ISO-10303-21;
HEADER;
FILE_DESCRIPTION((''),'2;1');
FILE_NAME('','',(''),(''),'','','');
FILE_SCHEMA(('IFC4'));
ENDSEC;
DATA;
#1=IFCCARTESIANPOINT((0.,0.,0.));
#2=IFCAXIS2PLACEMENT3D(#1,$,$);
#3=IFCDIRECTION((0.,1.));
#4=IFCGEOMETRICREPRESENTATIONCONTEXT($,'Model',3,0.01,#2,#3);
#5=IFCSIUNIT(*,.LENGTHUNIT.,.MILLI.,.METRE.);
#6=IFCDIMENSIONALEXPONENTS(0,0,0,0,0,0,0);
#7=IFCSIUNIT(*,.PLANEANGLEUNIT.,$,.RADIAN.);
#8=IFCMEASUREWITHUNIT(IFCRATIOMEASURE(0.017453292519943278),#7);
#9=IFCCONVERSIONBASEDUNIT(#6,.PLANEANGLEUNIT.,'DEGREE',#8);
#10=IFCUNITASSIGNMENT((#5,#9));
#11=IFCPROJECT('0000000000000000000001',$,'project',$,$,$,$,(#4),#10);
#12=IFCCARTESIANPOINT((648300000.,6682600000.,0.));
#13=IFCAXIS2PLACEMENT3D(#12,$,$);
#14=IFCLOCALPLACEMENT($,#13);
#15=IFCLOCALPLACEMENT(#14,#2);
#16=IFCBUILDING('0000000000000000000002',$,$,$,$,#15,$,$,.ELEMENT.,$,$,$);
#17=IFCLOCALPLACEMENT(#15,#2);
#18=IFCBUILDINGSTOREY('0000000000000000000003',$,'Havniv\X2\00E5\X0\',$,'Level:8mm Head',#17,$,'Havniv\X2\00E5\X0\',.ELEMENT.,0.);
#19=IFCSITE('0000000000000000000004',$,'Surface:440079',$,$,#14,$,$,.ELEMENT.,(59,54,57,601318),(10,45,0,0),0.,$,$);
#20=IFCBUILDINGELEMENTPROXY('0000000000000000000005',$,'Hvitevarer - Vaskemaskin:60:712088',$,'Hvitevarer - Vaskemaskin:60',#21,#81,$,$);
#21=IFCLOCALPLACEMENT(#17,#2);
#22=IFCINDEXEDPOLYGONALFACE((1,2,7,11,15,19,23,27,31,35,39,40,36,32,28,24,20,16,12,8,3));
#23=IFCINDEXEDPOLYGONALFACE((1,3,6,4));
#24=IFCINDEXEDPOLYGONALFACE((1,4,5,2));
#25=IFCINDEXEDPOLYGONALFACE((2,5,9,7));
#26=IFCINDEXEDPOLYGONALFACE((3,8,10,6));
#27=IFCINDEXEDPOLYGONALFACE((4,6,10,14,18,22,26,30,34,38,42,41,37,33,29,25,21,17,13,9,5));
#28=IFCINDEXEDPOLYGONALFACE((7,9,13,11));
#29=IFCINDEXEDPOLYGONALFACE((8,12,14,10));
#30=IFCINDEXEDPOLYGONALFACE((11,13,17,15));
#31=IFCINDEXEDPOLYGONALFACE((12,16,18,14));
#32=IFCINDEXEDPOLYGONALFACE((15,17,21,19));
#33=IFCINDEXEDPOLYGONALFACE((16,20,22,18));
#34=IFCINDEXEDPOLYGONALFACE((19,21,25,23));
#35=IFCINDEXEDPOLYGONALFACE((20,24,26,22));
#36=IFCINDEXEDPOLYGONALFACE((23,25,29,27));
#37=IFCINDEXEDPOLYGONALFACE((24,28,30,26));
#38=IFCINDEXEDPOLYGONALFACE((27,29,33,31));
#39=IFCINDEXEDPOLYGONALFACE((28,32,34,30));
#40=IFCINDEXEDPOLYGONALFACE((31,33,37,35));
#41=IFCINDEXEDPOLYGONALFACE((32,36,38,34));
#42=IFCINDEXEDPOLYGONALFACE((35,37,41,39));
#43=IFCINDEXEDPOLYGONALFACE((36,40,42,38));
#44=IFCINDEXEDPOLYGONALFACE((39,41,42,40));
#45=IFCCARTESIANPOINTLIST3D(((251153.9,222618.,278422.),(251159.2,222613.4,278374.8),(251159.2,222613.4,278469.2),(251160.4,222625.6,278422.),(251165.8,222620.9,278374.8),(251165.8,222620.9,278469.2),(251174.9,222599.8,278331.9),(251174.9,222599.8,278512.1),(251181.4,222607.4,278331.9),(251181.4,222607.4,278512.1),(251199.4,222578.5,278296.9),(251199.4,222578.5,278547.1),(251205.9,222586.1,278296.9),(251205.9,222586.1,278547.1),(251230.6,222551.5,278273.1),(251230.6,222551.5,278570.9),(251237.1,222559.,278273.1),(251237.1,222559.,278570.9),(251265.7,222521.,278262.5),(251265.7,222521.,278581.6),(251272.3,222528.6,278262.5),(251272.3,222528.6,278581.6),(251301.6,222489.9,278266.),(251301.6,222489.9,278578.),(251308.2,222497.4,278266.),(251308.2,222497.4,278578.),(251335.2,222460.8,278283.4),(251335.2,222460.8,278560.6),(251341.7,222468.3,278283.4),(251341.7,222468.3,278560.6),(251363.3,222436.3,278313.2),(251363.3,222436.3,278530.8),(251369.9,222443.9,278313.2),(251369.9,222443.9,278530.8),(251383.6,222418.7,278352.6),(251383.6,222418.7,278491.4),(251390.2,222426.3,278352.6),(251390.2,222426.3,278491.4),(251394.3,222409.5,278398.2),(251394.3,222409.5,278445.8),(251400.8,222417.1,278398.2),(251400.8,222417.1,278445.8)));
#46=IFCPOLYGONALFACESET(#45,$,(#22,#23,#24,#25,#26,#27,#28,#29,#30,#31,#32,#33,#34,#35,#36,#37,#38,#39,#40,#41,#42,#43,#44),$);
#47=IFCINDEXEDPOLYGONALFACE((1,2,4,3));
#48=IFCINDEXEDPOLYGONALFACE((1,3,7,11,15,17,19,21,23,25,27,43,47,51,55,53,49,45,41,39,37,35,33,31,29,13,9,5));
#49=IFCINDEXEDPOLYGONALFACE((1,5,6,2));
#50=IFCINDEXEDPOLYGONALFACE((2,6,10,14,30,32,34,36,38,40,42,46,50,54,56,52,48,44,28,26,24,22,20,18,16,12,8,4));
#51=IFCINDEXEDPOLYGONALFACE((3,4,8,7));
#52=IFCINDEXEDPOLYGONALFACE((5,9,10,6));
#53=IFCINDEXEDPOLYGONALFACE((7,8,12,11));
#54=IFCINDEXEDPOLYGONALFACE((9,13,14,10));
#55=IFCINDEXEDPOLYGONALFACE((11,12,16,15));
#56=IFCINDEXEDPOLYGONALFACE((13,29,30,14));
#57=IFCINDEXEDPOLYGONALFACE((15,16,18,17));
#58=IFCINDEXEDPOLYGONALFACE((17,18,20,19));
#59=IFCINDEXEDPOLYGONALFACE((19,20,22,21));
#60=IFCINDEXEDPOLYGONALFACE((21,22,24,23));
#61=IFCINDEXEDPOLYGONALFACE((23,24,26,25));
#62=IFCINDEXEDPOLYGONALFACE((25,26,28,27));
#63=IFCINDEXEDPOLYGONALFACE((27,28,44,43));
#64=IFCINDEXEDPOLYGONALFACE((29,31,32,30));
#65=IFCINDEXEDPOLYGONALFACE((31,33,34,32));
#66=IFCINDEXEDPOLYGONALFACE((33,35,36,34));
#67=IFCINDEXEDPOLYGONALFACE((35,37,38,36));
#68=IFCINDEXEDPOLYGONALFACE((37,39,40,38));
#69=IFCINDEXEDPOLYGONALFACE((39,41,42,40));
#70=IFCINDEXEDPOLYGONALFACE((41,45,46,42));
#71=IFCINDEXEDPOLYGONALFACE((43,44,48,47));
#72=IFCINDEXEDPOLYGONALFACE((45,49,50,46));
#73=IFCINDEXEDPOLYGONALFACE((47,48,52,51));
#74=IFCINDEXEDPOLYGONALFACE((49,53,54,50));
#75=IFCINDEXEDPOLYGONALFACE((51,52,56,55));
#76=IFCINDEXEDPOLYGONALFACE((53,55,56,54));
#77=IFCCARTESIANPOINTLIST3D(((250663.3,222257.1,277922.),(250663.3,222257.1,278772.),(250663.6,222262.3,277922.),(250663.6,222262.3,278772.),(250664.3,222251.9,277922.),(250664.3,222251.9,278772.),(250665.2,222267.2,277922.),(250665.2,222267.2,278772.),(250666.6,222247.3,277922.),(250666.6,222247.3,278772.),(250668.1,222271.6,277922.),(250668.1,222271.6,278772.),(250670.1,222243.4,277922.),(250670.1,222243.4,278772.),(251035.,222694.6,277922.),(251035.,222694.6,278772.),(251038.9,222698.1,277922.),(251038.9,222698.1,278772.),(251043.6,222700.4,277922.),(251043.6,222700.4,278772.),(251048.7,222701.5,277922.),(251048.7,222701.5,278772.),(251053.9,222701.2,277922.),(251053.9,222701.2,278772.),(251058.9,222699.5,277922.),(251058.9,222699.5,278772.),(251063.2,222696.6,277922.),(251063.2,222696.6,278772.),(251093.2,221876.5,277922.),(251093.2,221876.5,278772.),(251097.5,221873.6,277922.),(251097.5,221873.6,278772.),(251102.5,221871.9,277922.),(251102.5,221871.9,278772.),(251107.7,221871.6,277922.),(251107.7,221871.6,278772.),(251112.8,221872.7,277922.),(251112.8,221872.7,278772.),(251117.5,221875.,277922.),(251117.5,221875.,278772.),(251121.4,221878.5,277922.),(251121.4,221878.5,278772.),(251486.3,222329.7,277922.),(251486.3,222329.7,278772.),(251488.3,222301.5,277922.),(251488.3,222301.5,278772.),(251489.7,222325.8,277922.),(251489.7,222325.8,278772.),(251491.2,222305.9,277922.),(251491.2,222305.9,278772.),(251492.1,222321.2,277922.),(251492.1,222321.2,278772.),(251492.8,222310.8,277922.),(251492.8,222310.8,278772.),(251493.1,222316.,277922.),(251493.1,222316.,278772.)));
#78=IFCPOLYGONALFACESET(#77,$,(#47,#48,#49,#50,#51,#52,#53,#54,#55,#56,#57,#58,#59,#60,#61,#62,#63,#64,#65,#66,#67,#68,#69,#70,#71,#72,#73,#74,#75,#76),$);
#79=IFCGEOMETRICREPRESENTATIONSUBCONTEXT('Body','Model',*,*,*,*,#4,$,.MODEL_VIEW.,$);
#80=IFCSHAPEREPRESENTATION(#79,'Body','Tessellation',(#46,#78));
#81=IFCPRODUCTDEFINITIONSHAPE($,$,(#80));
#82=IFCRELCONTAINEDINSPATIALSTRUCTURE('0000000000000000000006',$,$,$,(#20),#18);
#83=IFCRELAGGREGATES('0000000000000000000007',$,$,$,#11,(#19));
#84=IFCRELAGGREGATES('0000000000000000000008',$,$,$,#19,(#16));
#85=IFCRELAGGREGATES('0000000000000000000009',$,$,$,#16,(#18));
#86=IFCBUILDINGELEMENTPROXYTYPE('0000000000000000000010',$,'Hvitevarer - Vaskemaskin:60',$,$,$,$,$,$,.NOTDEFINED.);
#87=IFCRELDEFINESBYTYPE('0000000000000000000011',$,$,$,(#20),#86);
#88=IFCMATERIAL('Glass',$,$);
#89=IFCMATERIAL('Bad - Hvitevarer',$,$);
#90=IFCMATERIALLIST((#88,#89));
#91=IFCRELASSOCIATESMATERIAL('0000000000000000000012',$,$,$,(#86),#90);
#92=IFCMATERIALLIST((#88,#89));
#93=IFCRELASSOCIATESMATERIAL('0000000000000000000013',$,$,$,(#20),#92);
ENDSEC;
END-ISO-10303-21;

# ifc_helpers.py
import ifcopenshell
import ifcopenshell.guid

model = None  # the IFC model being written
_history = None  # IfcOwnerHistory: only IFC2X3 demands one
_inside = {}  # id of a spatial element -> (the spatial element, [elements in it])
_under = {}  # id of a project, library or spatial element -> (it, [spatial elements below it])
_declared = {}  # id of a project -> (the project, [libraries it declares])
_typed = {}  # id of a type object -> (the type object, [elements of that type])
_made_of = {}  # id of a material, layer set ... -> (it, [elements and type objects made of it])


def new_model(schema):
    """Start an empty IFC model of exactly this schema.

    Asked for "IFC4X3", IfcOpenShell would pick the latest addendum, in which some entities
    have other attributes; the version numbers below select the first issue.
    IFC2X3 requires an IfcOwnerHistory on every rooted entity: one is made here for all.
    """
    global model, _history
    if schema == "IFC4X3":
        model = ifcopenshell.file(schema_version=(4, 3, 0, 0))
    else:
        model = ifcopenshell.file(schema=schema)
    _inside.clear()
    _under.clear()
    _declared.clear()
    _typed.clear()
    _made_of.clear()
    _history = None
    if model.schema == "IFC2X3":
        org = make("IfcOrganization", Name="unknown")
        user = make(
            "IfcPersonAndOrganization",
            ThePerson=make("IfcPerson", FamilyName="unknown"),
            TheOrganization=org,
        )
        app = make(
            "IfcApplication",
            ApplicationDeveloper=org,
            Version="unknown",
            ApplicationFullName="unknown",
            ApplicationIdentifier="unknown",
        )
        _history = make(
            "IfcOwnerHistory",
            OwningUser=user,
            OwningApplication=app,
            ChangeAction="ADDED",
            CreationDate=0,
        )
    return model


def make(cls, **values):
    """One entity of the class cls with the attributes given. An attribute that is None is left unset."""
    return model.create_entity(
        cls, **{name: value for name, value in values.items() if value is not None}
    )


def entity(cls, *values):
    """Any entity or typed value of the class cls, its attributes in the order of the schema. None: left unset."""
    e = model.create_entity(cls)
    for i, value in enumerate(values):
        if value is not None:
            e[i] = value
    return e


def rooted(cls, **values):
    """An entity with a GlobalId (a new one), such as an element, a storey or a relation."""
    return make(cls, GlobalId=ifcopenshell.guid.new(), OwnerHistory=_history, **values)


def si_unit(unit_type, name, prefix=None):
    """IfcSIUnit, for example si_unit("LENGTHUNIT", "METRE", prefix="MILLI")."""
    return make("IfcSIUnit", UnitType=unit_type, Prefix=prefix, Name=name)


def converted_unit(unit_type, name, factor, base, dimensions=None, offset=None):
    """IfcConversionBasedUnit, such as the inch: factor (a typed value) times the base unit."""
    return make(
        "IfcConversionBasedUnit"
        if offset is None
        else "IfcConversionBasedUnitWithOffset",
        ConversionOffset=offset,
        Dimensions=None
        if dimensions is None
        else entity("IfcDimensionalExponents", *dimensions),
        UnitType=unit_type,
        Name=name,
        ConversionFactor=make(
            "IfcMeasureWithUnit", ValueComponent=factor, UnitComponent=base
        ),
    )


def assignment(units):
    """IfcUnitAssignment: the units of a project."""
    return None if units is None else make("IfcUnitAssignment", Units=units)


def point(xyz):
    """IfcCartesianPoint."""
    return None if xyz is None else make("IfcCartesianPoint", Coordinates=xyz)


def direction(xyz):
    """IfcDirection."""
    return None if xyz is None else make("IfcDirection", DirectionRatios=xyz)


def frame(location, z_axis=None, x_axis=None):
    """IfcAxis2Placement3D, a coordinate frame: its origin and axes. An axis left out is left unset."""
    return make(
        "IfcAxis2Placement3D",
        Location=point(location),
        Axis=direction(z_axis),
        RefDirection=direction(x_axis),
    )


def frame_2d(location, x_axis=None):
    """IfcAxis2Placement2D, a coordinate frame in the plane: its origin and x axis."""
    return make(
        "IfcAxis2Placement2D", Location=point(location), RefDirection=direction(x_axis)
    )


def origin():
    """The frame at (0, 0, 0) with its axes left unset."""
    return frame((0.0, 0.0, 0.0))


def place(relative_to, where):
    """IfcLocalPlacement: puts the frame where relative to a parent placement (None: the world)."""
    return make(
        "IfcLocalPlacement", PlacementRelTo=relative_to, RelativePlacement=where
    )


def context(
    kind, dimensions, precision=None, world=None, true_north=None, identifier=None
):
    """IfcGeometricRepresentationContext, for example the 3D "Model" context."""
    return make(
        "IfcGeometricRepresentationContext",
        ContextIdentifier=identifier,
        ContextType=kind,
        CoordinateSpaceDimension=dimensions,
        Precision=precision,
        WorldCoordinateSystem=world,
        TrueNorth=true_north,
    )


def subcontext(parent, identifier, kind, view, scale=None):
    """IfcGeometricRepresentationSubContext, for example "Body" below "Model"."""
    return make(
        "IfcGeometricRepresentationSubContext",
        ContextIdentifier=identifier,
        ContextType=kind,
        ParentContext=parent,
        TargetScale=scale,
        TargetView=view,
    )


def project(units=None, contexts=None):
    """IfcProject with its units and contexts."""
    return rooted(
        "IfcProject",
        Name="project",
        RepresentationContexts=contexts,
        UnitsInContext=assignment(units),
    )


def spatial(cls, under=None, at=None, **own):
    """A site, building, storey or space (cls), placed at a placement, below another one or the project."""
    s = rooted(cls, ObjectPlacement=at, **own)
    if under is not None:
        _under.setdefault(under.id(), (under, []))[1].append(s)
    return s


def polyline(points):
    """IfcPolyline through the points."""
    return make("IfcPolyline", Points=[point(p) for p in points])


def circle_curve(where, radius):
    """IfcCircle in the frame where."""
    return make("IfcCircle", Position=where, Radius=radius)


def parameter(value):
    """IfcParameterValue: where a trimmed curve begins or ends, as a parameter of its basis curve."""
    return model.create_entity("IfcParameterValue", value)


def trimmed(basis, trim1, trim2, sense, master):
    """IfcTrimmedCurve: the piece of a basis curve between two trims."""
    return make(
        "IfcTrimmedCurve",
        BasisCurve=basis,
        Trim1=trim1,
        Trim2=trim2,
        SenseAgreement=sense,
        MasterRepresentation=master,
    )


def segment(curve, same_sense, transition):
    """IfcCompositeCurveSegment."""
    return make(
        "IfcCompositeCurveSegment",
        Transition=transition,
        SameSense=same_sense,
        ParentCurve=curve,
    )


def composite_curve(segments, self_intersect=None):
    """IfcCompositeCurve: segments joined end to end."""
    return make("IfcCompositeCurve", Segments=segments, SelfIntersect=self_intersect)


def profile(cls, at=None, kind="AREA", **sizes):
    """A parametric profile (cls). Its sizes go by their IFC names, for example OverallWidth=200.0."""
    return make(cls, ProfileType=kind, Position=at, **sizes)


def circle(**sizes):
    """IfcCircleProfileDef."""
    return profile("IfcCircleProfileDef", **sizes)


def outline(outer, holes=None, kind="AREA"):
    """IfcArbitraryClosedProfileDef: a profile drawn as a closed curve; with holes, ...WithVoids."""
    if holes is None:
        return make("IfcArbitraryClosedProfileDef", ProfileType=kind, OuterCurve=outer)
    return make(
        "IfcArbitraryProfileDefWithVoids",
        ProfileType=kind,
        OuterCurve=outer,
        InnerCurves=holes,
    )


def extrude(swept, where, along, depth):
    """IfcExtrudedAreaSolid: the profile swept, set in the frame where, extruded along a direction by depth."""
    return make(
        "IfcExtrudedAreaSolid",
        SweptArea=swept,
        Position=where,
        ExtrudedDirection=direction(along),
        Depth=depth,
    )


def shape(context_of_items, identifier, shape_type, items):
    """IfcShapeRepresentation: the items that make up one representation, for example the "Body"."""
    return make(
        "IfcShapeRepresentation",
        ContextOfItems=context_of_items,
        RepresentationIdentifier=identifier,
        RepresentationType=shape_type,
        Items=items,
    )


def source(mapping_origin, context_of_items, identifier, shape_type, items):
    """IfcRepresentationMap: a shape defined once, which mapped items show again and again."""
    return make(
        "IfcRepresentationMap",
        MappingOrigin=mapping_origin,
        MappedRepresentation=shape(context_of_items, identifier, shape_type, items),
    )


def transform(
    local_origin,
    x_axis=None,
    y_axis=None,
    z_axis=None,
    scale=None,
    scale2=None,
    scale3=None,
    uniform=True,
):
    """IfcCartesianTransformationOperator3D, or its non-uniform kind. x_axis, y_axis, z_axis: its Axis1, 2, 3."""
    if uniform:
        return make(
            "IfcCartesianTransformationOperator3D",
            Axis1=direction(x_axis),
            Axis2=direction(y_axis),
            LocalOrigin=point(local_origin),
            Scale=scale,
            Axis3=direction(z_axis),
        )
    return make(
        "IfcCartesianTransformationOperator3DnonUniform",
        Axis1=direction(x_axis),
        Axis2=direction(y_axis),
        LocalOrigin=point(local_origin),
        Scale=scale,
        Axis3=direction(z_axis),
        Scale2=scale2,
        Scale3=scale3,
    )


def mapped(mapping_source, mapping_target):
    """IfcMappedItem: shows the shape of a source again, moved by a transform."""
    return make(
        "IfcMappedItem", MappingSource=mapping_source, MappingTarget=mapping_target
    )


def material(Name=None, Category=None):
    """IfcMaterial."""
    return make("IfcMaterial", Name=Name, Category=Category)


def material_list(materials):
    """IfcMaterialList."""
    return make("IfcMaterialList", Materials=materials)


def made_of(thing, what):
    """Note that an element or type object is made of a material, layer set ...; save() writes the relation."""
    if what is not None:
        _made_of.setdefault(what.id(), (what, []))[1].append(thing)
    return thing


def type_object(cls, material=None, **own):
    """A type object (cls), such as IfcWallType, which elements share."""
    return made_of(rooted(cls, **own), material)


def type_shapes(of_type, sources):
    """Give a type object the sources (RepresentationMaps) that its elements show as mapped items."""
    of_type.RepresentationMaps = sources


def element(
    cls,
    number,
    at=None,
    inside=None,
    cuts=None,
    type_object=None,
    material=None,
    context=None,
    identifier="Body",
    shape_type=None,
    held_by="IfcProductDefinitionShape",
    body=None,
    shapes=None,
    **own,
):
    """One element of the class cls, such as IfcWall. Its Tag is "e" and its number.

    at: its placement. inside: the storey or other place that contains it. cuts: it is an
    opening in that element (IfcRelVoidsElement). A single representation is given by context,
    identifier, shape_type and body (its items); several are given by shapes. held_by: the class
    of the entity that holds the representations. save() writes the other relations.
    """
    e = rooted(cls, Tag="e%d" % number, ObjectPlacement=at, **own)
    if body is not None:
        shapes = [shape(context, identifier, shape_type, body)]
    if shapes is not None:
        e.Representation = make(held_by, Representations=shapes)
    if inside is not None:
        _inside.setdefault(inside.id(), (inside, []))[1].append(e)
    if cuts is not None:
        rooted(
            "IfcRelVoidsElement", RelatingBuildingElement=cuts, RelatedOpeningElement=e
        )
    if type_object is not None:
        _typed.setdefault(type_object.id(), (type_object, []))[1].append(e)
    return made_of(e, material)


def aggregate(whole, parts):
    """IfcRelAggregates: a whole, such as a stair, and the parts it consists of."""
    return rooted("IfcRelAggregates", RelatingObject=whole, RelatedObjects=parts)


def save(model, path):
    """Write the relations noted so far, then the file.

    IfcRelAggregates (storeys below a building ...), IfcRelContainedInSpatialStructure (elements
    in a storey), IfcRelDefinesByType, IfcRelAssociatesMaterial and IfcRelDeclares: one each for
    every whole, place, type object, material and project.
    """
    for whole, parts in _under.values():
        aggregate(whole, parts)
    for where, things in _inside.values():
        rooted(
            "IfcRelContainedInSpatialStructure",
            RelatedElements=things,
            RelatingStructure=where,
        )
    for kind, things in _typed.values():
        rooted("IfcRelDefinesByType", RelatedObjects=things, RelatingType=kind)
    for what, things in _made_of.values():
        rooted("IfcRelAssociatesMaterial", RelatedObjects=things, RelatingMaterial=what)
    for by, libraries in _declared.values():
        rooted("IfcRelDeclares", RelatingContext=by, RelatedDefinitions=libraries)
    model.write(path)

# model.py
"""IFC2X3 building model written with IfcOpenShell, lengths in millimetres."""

from ifc_helpers import new_model, entity, si_unit, converted_unit, direction, frame, frame_2d, origin, place, context, subcontext, project, spatial, polyline, circle_curve, parameter, trimmed, segment, composite_curve, circle, outline, extrude, source, transform, mapped, material, material_list, type_object, type_shapes, element, save


model = new_model("IFC2X3")

# Units and contexts
model_context = context("Model", 3, precision=0.01, world=origin(), true_north=direction((0.0, 1.0)))
body_context = subcontext(model_context, "Body", "Model", "MODEL_VIEW")
ifc_project = project(units=[si_unit("LENGTHUNIT", "METRE", prefix="MILLI"), converted_unit("PLANEANGLEUNIT", "DEGREE", entity("IfcRatioMeasure", 0.017453292519943278), si_unit("PLANEANGLEUNIT", "RADIAN"), dimensions=[0, 0, 0, 0, 0, 0, 0])], contexts=[model_context])

# Site, building, storey
site_placement = place(None, frame((648300000.0, 6682600000.0, 0.0)))
site = spatial("IfcSite", under=ifc_project, at=site_placement, Name="Surface:440079", CompositionType="ELEMENT", RefLatitude=(59, 54, 57, 601318), RefLongitude=(10, 45, 0, 0), RefElevation=0.0)
building_placement = place(site_placement, origin())
building = spatial("IfcBuilding", under=site, at=building_placement, CompositionType="ELEMENT")
storey_placement = place(building_placement, origin())
storey = spatial("IfcBuildingStorey", under=building, at=storey_placement, Name="Havnivå", ObjectType="Level:8mm Head", LongName="Havnivå", CompositionType="ELEMENT", Elevation=0.0)

# Shared definitions
ifc_material_1 = material(Name="Glass")

# Building element proxy
ifc_material_2 = material(Name="Bad - Hvitevarer")
ifc_material_list_1 = material_list([ifc_material_1, ifc_material_2])
building_element_proxy_type = type_object("IfcBuildingElementProxyType", Name="Hvitevarer - Vaskemaskin:60", PredefinedType="NOTDEFINED", material=ifc_material_list_1)
shared_shape_1 = source(origin(), body_context, "Body", "SweptSolid", [
    extrude(circle(Radius=160.0, at=frame_2d((0.0, 0.0), x_axis=(1.0, 0.0))), frame((98.2, -671.5, 500.0), z_axis=(0.0, 1.0, 0.0), x_axis=(1.0, 0.0, 0.0)), (0.0, 0.0, 1.0), 10.0),
    extrude(outline(composite_curve([segment(trimmed(circle_curve(frame_2d((-280.0, -280.0), x_axis=(1.0, 0.0)), 20.0), [parameter(180.0)], [parameter(270.0)], True, "PARAMETER"), True, "CONTINUOUS"), segment(polyline([(-280.0, -300.0), (280.0, -300.0)]), True, "CONTINUOUS"), segment(trimmed(circle_curve(frame_2d((280.0, -280.0), x_axis=(1.0, 0.0)), 20.0), [parameter(270.0)], [parameter(0.0)], True, "PARAMETER"), True, "CONTINUOUS"), segment(polyline([(300.0, -280.0), (300.0, 280.0)]), True, "CONTINUOUS"), segment(trimmed(circle_curve(frame_2d((280.0, 280.0), x_axis=(1.0, 0.0)), 20.0), [parameter(0.0)], [parameter(90.0)], True, "PARAMETER"), True, "CONTINUOUS"), segment(polyline([(280.0, 300.0), (-280.0, 300.0)]), True, "CONTINUOUS"), segment(trimmed(circle_curve(frame_2d((-280.0, 280.0), x_axis=(1.0, 0.0)), 20.0), [parameter(90.0)], [parameter(180.0)], True, "PARAMETER"), True, "CONTINUOUS"), segment(polyline([(-300.0, 280.0), (-300.0, -280.0)]), True, "CONTINUOUS")], self_intersect=False)), frame((98.2, -361.5, 0.0)), (0.0, 0.0, 1.0), 850.0),
])
type_shapes(building_element_proxy_type, [shared_shape_1])
ifc_material_list_2 = material_list([ifc_material_1, ifc_material_2])
proxy_1_placement = place(storey_placement, frame((250915.5, 221949.1, 277922.0), z_axis=(0.0, 0.0, 1.0), x_axis=(-0.755467, 0.655187, 0.0)))
element("IfcBuildingElementProxy", 1, at=proxy_1_placement, inside=storey, type_object=building_element_proxy_type, material=ifc_material_list_2, Name="Hvitevarer - Vaskemaskin:60:712088", ObjectType="Hvitevarer - Vaskemaskin:60", context=body_context, shape_type="MappedRepresentation", body=[
    mapped(shared_shape_1, transform((0.0, 0.0, 0.0), scale=1.0)),
])

save(model, "model.ifc")
